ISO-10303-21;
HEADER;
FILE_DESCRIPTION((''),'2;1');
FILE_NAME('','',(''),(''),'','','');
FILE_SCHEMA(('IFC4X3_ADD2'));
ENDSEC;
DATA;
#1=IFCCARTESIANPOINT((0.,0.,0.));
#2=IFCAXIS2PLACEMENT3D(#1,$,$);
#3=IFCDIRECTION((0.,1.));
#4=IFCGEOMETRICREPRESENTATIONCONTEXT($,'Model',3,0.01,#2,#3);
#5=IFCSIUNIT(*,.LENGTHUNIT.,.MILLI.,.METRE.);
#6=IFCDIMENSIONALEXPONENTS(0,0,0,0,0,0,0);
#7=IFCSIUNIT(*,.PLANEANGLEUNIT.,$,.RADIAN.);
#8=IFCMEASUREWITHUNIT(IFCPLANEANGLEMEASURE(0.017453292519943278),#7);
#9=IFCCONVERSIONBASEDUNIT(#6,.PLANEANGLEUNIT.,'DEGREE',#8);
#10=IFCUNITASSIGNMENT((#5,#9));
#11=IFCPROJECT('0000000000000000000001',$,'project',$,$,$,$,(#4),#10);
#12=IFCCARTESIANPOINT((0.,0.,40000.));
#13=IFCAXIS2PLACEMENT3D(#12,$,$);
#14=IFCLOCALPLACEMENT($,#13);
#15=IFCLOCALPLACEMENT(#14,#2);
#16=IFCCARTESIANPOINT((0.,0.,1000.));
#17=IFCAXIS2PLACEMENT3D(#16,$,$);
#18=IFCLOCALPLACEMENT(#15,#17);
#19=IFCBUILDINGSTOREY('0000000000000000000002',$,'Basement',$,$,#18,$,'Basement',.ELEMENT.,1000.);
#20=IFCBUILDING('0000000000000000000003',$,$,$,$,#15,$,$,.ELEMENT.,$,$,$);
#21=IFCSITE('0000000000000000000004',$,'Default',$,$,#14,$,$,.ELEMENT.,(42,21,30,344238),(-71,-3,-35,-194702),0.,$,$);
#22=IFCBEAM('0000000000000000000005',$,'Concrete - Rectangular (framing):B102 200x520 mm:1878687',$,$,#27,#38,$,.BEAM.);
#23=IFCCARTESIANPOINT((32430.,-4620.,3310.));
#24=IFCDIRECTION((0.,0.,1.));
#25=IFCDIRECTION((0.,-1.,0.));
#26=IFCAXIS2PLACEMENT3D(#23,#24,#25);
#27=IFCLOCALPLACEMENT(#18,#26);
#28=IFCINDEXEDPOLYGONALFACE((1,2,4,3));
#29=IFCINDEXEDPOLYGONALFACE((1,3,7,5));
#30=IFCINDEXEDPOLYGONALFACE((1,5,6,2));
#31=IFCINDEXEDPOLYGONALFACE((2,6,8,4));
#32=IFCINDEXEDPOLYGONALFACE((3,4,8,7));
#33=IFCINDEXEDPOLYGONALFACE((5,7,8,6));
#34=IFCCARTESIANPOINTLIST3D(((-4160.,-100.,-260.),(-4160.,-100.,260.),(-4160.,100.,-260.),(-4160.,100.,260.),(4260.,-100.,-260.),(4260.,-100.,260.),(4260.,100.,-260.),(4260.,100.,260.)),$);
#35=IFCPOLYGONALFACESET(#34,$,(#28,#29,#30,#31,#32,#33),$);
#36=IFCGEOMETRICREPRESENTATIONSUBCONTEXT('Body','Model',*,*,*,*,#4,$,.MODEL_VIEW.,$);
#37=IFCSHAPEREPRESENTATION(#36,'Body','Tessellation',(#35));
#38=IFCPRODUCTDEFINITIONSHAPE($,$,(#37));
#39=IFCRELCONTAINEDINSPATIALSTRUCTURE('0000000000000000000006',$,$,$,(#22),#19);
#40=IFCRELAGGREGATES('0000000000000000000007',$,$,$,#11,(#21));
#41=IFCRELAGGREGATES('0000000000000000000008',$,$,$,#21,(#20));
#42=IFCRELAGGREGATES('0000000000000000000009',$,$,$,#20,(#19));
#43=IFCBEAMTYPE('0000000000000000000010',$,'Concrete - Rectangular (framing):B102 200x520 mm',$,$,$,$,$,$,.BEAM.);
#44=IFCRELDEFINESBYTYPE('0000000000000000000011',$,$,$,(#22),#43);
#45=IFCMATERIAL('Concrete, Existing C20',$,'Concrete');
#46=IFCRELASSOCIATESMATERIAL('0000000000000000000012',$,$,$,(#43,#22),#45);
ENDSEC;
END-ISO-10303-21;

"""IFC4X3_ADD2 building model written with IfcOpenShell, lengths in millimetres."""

from ifc_helpers import new_model, entity, si_unit, converted_unit, direction, frame, origin, origin_2d_with_axis, place, context, subcontext, project, spatial, rectangle, extrude, source, transform, mapped, material, material_profile, profile_set, profile_usage, type_object, type_shapes, element, save


model = new_model("IFC4X3_ADD2")

# Units and contexts
model_context = context("Model", 3, precision=0.01, world=origin(), true_north=direction((0.0, 1.0)))
body_context = subcontext(model_context, "Body", "Model", "MODEL_VIEW")
ifc_project = project(units=[si_unit("LENGTHUNIT", "METRE", prefix="MILLI"), converted_unit("PLANEANGLEUNIT", "DEGREE", entity("IfcPlaneAngleMeasure", 0.017453292519943278), si_unit("PLANEANGLEUNIT", "RADIAN"), dimensions=[0, 0, 0, 0, 0, 0, 0])], contexts=[model_context])

# Site, building, storey
site_placement = place(None, frame((0.0, 0.0, 40000.0)))
site = spatial("IfcSite", under=ifc_project, at=site_placement, Name="Default", CompositionType="ELEMENT", RefLatitude=(42, 21, 30, 344238), RefLongitude=(-71, -3, -35, -194702), RefElevation=0.0)
building_placement = place(site_placement, origin())
building = spatial("IfcBuilding", under=site, at=building_placement, CompositionType="ELEMENT")
storey_placement = place(building_placement, frame((0.0, 0.0, 1000.0)))
storey = spatial("IfcBuildingStorey", under=building, at=storey_placement, Name="Basement", LongName="Basement", CompositionType="ELEMENT", Elevation=1000.0)

# Shared definitions
ifc_material_1 = material(Name="Concrete, Existing C20", Category="Concrete")

# Beam
ifc_material_profile_1 = material_profile(ifc_material_1, rectangle(XDim=8519.8, YDim=200.0, at=origin_2d_with_axis()), Name="B102 200x520 mm")
ifc_profile_set_1 = profile_set([ifc_material_profile_1], Name="B102 200x520 mm")
ifc_profile_usage_1 = profile_usage(ifc_profile_set_1, cardinal=8)
beam_type_1 = type_object("IfcBeamType", Name="Concrete - Rectangular (framing):B102 200x520 mm", PredefinedType="BEAM", material=ifc_profile_set_1)
shared_shape_1 = source(origin(), body_context, "Body", "SweptSolid", [
    extrude(rectangle(XDim=8420.0, YDim=200.0, at=origin_2d_with_axis()), frame((50.0, 0.0, -260.0), z_axis=(0.0, 0.0, 1.0), x_axis=(-1.0, 0.0, 0.0)), (0.0, 0.0, 1.0), 520.0),
])
type_shapes(beam_type_1, [shared_shape_1])
beam_placement = place(storey_placement, frame((32430.0, -4620.0, 3310.0), z_axis=(0.0, 0.0, 1.0), x_axis=(0.0, -1.0, 0.0)))
element("IfcBeam", 1, at=beam_placement, inside=storey, type_object=beam_type_1, material=ifc_profile_usage_1, Name="Concrete - Rectangular (framing):B102 200x520 mm:1878687", PredefinedType="BEAM", context=body_context, shape_type="MappedRepresentation", body=[
    mapped(shared_shape_1, transform((0.0, 0.0, 0.0), scale=1.0)),
])

save(model, "model.ifc")
